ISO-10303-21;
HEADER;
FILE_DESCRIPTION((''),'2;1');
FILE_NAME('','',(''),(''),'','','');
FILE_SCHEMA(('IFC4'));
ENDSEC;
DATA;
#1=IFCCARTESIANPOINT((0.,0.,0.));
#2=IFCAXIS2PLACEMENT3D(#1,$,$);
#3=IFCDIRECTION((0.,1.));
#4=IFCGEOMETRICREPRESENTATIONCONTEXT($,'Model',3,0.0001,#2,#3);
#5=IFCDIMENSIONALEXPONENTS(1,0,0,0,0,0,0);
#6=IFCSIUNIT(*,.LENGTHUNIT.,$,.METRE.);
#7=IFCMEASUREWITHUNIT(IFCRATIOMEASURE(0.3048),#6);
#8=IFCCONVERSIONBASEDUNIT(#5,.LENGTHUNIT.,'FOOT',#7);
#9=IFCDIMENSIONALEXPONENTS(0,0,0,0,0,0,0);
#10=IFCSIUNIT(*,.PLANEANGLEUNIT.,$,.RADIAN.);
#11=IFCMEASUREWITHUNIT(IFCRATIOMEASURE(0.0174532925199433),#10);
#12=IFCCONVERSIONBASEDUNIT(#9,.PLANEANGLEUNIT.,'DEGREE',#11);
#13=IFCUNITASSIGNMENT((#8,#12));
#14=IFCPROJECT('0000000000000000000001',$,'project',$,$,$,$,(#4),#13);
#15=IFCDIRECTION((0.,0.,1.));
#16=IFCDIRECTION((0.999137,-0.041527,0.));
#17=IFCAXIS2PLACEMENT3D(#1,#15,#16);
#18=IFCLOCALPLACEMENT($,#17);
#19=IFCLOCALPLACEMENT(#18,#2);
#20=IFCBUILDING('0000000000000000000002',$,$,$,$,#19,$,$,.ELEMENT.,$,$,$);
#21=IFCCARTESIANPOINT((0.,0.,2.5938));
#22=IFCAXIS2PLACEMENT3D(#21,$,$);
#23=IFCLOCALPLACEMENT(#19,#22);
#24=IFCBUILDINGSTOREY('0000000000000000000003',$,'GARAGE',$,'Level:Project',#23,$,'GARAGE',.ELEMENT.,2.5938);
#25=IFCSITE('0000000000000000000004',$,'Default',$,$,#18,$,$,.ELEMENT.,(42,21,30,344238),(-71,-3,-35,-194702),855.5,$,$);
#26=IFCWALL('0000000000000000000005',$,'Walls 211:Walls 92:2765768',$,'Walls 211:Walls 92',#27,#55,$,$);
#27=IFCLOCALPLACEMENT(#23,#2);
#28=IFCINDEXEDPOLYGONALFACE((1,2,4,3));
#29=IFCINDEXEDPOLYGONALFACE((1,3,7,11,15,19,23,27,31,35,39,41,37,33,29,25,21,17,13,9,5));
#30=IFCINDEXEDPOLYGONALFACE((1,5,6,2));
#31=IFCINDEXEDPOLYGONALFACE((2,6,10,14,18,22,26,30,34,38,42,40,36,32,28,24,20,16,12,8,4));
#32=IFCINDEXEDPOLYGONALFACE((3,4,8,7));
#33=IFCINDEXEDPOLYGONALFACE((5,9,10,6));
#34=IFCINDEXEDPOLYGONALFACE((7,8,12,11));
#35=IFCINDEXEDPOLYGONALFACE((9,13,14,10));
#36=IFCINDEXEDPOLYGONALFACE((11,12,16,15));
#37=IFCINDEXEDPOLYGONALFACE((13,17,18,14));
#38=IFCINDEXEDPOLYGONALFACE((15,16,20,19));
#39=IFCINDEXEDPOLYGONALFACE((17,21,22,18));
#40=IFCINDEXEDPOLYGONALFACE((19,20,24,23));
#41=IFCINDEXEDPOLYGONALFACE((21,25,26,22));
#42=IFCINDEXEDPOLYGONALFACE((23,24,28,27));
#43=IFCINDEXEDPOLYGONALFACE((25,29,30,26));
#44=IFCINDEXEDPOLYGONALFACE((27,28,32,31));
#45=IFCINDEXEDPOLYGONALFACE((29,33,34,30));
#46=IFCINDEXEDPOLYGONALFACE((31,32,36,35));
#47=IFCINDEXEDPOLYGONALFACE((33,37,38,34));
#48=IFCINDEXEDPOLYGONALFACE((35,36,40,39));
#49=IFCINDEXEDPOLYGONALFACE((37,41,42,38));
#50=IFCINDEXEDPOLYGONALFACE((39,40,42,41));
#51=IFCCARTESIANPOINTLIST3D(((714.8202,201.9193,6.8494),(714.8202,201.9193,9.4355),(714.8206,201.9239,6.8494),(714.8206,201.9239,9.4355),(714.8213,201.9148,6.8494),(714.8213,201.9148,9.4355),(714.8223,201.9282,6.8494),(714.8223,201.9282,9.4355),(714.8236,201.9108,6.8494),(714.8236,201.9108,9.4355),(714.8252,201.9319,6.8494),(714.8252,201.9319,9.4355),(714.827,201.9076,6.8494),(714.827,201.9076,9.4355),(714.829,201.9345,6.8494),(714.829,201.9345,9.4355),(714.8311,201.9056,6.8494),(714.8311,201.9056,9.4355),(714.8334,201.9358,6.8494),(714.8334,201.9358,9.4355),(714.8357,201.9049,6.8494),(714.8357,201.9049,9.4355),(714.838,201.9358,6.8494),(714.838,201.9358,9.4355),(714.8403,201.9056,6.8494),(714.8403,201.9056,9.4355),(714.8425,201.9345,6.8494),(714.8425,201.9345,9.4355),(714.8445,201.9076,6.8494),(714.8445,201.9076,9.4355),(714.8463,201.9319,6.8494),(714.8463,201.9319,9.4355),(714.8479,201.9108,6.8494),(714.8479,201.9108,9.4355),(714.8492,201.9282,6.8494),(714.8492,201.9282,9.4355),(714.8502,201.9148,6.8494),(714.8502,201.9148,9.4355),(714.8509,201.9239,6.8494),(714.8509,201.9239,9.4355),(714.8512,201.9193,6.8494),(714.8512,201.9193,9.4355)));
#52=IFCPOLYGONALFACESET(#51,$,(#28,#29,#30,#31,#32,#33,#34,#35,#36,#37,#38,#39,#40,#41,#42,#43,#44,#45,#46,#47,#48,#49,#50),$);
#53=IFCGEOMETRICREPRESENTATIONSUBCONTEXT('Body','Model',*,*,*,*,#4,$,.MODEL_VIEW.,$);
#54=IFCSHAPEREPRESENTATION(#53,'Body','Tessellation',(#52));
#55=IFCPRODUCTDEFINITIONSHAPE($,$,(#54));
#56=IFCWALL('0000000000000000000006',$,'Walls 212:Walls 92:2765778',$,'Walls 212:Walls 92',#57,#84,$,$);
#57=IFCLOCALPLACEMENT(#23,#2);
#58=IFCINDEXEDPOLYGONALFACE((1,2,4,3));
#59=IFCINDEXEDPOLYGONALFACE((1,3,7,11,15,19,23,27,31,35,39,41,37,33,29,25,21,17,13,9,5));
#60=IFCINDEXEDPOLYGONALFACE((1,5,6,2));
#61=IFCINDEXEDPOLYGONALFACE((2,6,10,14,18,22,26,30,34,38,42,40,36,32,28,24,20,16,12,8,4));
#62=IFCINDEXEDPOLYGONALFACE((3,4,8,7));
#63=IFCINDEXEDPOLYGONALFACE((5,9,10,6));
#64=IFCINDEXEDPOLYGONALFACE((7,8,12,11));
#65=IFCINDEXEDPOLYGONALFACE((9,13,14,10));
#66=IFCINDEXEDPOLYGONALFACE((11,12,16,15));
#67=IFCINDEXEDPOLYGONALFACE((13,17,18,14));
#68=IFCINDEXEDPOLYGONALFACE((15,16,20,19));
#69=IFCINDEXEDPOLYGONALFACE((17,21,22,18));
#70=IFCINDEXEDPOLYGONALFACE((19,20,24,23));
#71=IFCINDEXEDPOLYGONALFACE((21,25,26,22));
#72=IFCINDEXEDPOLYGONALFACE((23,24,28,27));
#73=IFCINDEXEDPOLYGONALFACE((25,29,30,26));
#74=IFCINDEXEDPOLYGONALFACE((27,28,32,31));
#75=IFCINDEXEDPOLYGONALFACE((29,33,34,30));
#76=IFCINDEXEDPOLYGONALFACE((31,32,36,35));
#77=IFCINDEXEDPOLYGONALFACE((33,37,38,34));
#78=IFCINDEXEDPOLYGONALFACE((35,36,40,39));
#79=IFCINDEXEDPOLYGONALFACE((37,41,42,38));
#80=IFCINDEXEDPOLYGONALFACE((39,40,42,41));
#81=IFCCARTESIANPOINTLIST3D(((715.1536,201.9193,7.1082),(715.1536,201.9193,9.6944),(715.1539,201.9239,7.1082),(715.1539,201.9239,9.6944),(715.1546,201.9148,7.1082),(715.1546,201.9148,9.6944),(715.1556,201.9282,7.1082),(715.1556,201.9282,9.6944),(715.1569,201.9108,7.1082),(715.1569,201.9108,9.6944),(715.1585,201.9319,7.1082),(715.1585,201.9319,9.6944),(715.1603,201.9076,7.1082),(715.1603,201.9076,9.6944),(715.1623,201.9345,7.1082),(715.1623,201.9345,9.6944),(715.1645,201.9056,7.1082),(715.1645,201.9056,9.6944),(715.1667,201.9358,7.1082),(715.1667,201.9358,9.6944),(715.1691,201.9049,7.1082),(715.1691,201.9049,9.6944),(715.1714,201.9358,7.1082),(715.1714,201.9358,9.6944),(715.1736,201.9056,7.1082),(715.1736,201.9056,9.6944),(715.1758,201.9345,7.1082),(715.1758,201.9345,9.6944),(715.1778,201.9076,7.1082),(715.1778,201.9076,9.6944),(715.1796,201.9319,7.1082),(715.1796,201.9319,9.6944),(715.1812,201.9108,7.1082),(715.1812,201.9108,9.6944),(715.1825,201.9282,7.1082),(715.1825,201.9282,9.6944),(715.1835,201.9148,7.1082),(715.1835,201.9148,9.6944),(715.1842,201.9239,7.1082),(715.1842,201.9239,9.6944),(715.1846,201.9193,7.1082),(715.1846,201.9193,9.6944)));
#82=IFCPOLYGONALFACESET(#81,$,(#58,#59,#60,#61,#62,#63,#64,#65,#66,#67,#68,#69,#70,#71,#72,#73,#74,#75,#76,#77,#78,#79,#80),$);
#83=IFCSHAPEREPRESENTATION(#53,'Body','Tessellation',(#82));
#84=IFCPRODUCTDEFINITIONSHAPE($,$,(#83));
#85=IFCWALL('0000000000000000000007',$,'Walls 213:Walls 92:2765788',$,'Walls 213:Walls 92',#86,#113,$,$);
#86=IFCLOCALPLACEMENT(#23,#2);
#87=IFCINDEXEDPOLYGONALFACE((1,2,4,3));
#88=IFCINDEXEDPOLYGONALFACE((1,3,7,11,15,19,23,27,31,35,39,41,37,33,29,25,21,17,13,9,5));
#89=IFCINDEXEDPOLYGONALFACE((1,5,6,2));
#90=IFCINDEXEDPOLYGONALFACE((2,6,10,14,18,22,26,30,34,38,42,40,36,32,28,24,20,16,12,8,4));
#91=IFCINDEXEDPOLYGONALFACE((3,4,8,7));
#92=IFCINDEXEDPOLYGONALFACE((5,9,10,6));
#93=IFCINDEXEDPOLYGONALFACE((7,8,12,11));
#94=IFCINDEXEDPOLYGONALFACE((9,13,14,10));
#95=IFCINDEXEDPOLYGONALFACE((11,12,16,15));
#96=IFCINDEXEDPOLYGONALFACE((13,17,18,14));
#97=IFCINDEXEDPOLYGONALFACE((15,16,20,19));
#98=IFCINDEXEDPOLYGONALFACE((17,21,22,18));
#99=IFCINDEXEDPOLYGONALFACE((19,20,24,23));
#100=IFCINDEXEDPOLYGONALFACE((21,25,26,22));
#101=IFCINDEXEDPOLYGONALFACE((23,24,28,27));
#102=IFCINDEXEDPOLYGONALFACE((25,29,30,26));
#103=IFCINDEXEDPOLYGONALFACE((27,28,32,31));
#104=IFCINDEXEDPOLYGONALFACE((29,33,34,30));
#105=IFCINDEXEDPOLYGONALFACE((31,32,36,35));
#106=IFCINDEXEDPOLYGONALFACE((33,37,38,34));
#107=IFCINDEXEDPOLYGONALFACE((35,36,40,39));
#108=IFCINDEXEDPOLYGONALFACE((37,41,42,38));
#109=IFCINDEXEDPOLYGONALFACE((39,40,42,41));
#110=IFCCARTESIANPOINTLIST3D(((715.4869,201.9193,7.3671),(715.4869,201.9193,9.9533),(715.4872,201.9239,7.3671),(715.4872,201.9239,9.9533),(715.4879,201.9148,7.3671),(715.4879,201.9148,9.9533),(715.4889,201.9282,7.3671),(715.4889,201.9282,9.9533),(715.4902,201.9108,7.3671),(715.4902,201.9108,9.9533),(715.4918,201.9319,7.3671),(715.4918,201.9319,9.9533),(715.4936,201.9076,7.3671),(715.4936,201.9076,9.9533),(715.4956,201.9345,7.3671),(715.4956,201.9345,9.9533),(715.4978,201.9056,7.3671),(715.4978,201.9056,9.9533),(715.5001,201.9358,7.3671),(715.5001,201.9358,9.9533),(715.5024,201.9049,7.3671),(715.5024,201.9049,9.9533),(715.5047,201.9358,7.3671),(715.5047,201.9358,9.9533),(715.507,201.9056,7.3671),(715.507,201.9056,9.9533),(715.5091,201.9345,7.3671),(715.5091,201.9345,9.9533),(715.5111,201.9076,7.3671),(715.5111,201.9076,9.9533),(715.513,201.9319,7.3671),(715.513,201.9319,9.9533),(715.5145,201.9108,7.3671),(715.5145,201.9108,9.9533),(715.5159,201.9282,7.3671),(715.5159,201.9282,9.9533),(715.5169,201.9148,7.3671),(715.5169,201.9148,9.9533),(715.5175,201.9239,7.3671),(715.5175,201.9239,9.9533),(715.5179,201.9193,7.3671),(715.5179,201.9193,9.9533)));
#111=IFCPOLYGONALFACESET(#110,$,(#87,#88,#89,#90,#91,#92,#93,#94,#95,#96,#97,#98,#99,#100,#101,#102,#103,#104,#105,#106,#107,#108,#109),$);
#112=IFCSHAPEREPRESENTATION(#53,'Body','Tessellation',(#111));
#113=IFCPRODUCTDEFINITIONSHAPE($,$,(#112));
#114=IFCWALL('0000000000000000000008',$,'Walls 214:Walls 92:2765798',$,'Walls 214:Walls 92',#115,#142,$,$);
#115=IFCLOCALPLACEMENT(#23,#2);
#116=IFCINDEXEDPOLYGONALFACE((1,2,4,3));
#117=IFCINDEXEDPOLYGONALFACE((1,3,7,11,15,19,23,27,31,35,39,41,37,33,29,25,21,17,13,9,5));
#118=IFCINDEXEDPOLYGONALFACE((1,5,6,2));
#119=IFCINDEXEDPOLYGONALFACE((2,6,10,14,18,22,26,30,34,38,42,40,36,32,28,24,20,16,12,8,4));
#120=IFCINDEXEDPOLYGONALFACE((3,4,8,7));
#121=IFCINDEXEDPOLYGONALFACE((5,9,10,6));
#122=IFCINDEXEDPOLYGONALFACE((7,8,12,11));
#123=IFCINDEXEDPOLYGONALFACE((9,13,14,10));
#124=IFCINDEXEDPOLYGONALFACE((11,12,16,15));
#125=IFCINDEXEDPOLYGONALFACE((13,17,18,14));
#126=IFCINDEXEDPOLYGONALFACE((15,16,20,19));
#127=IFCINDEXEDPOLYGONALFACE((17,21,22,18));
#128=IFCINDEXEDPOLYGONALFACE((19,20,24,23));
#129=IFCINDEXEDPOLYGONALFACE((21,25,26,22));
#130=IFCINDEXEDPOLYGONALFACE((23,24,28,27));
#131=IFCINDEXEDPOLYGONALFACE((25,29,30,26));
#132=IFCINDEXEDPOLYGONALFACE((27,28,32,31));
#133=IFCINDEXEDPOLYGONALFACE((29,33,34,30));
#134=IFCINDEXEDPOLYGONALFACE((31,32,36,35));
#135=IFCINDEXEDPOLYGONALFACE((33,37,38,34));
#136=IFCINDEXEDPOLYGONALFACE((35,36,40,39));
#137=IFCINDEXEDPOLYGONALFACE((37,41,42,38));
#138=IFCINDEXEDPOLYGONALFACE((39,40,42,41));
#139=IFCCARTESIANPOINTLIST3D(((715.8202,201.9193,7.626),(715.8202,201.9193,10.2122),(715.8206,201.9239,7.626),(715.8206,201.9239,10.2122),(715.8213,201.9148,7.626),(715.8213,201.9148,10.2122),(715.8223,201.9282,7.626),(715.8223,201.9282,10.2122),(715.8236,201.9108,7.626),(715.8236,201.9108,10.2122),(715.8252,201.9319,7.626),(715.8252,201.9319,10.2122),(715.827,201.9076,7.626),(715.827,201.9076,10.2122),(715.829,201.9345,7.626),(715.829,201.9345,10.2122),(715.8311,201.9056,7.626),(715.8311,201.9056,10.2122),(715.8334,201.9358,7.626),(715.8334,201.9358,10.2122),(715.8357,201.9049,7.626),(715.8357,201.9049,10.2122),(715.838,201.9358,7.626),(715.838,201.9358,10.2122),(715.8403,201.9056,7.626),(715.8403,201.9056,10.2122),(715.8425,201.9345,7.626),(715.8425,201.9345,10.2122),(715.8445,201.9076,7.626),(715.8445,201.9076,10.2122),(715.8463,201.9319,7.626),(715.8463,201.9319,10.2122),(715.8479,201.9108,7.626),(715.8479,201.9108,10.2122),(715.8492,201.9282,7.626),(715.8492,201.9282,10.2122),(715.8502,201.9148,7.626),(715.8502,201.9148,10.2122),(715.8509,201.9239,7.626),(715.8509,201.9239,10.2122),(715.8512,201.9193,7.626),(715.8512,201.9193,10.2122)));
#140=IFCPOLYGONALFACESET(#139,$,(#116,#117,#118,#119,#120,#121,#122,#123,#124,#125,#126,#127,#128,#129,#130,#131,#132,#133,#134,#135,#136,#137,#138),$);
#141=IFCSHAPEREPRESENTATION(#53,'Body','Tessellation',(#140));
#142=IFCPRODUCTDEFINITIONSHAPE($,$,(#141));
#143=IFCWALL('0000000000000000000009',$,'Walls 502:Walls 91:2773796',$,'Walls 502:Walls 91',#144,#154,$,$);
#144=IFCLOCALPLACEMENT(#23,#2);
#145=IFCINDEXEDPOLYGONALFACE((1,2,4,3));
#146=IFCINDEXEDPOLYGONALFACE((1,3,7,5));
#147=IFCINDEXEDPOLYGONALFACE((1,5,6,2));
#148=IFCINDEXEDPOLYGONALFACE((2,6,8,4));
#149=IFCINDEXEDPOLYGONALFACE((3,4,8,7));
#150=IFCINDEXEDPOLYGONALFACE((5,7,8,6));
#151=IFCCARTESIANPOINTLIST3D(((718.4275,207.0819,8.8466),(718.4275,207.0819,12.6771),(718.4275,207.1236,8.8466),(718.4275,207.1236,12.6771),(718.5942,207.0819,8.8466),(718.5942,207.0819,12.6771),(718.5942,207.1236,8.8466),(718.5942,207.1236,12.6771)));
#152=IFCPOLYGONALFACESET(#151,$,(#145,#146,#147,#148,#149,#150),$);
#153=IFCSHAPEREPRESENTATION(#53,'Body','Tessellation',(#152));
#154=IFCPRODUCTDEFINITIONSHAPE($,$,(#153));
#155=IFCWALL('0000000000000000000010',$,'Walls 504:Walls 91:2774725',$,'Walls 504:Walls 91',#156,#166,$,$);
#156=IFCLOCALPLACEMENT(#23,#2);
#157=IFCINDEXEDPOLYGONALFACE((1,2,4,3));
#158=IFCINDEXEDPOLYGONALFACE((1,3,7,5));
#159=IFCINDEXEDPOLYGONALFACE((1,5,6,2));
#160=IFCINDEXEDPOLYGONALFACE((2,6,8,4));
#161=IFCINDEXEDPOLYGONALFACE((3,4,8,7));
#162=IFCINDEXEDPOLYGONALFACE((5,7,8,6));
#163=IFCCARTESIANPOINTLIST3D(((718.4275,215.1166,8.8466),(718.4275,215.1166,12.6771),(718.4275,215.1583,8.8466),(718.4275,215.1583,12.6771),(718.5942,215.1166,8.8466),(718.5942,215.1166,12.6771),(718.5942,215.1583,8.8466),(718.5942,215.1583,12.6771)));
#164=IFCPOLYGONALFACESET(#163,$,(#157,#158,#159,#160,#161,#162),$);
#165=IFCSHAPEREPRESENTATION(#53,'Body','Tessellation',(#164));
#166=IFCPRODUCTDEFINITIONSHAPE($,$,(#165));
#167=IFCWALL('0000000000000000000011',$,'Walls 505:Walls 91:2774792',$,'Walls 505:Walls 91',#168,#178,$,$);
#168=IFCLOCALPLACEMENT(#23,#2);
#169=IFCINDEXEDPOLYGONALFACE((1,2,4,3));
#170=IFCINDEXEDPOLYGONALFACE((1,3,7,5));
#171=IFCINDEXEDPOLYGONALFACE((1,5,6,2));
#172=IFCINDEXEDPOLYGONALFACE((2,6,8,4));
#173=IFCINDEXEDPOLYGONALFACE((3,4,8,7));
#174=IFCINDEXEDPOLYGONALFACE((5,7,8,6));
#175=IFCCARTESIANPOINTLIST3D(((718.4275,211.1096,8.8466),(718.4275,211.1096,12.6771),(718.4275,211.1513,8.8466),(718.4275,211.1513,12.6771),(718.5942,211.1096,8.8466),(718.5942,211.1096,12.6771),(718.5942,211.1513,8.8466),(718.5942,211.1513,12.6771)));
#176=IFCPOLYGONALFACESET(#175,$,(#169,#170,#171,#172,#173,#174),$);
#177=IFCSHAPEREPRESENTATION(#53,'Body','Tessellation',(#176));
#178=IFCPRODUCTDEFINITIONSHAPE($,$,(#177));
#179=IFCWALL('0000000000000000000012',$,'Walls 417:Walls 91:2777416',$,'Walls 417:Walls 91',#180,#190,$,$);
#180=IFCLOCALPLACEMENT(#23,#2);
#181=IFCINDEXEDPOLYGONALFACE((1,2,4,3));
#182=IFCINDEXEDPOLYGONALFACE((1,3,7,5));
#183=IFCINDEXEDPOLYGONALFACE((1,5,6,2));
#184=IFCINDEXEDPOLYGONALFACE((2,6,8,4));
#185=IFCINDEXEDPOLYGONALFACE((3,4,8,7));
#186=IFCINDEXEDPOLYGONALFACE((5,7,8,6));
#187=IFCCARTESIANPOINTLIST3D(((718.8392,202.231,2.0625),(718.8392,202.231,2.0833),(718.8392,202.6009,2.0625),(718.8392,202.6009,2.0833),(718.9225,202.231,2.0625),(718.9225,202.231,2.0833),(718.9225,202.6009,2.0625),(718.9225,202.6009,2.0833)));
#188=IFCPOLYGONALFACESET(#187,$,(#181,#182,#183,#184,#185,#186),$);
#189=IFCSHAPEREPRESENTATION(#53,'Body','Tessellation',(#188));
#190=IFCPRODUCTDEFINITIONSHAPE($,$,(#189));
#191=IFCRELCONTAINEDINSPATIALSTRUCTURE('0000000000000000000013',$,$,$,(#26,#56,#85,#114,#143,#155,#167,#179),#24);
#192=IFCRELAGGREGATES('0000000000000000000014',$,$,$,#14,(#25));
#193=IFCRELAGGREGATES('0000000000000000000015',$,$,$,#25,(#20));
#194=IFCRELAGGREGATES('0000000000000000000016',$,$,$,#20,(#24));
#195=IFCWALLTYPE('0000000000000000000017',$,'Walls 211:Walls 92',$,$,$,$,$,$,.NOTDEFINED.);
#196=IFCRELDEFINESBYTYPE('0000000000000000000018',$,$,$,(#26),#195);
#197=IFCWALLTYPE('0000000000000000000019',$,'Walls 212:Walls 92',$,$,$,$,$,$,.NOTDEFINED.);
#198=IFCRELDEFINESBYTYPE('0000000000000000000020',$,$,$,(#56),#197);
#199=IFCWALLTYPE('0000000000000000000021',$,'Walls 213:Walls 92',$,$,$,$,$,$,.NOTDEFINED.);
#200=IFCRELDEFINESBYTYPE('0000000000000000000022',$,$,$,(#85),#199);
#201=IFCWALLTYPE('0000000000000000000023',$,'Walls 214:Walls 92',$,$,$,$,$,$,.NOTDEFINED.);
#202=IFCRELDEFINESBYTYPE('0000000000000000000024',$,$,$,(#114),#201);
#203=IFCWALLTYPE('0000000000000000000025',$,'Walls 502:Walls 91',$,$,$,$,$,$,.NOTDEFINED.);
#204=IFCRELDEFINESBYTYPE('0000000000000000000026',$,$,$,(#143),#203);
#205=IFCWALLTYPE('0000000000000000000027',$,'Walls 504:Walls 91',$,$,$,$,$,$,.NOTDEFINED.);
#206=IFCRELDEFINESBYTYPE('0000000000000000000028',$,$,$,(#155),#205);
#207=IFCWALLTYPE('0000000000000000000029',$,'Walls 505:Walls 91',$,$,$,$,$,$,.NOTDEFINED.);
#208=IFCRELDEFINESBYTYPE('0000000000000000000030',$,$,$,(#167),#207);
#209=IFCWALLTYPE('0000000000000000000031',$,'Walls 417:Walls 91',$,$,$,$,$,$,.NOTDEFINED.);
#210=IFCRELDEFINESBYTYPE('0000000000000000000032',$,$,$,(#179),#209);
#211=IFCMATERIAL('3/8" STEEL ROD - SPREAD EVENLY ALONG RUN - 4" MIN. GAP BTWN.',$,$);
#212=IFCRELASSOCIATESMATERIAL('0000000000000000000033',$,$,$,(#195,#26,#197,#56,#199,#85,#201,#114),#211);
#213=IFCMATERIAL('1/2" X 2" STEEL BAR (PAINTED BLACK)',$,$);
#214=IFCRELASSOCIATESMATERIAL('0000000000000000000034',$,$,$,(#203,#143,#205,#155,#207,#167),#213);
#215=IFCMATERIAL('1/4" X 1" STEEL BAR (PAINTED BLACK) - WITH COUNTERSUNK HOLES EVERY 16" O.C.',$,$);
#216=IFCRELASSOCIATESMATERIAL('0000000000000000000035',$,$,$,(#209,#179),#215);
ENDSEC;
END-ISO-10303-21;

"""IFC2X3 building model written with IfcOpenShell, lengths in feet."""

from ifc_helpers import new_model, entity, si_unit, converted_unit, direction, frame, frame_2d, origin, origin_2d_with_axis, place, context, subcontext, project, spatial, rectangle, circle, extrude, material, type_object, element, save


model = new_model("IFC2X3")

# Units and contexts
model_context = context("Model", 3, precision=0.0001, world=origin(), true_north=direction((0.0, 1.0)))
body_context = subcontext(model_context, "Body", "Model", "MODEL_VIEW")
ifc_project = project(units=[converted_unit("LENGTHUNIT", "FOOT", entity("IfcRatioMeasure", 0.3048), si_unit("LENGTHUNIT", "METRE"), dimensions=[1, 0, 0, 0, 0, 0, 0]), converted_unit("PLANEANGLEUNIT", "DEGREE", entity("IfcRatioMeasure", 0.0174532925199433), si_unit("PLANEANGLEUNIT", "RADIAN"), dimensions=[0, 0, 0, 0, 0, 0, 0])], contexts=[model_context])

# Site, building, storey
site_placement = place(None, frame((0.0, 0.0, 0.0), z_axis=(0.0, 0.0, 1.0), x_axis=(0.999137, -0.041527, 0.0)))
site = spatial("IfcSite", under=ifc_project, at=site_placement, Name="Default", CompositionType="ELEMENT", RefLatitude=(42, 21, 30, 344238), RefLongitude=(-71, -3, -35, -194702), RefElevation=855.5)
building_placement = place(site_placement, origin())
building = spatial("IfcBuilding", under=site, at=building_placement, CompositionType="ELEMENT")
storey_placement = place(building_placement, frame((0.0, 0.0, 2.5938)))
storey = spatial("IfcBuildingStorey", under=building, at=storey_placement, Name="GARAGE", ObjectType="Level:Project", LongName="GARAGE", CompositionType="ELEMENT", Elevation=2.5938)

# Walls
ifc_material_1 = material(Name="3/8\" STEEL ROD - SPREAD EVENLY ALONG RUN - 4\" MIN. GAP BTWN.")
wall_type_1 = type_object("IfcWallType", Name="Walls 211:Walls 92", PredefinedType="NOTDEFINED", material=ifc_material_1)
wall_1_placement = place(storey_placement, frame((714.8202, 201.9049, 6.8494)))
element("IfcWall", 1, at=wall_1_placement, inside=storey, type_object=wall_type_1, material=ifc_material_1, Name="Walls 211:Walls 92:2765768", ObjectType="Walls 211:Walls 92", context=body_context, shape_type="SweptSolid", body=[
    extrude(circle(Radius=0.0155, at=origin_2d_with_axis()), frame((0.0155, 0.0155, 0.0), z_axis=(0.0, 0.0, 1.0), x_axis=(0.0, -1.0, 0.0)), (0.0, 0.0, 1.0), 2.5862),
])
wall_type_2 = type_object("IfcWallType", Name="Walls 212:Walls 92", PredefinedType="NOTDEFINED", material=ifc_material_1)
wall_2_placement = place(storey_placement, frame((715.1535, 201.9049, 7.1082)))
element("IfcWall", 2, at=wall_2_placement, inside=storey, type_object=wall_type_2, material=ifc_material_1, Name="Walls 212:Walls 92:2765778", ObjectType="Walls 212:Walls 92", context=body_context, shape_type="SweptSolid", body=[
    extrude(circle(Radius=0.0155, at=origin_2d_with_axis()), frame((0.0155, 0.0155, 0.0), z_axis=(0.0, 0.0, 1.0), x_axis=(0.0, -1.0, 0.0)), (0.0, 0.0, 1.0), 2.5862),
])
wall_type_3 = type_object("IfcWallType", Name="Walls 213:Walls 92", PredefinedType="NOTDEFINED", material=ifc_material_1)
wall_3_placement = place(storey_placement, frame((715.4869, 201.9049, 7.3671)))
element("IfcWall", 3, at=wall_3_placement, inside=storey, type_object=wall_type_3, material=ifc_material_1, Name="Walls 213:Walls 92:2765788", ObjectType="Walls 213:Walls 92", context=body_context, shape_type="SweptSolid", body=[
    extrude(circle(Radius=0.0155, at=origin_2d_with_axis()), frame((0.0155, 0.0155, 0.0), z_axis=(0.0, 0.0, 1.0), x_axis=(0.0, -1.0, 0.0)), (0.0, 0.0, 1.0), 2.5862),
])
wall_type_4 = type_object("IfcWallType", Name="Walls 214:Walls 92", PredefinedType="NOTDEFINED", material=ifc_material_1)
wall_4_placement = place(storey_placement, frame((715.8202, 201.9049, 7.626)))
element("IfcWall", 4, at=wall_4_placement, inside=storey, type_object=wall_type_4, material=ifc_material_1, Name="Walls 214:Walls 92:2765798", ObjectType="Walls 214:Walls 92", context=body_context, shape_type="SweptSolid", body=[
    extrude(circle(Radius=0.0155, at=origin_2d_with_axis()), frame((0.0155, 0.0155, 0.0), z_axis=(0.0, 0.0, 1.0), x_axis=(0.0, -1.0, 0.0)), (0.0, 0.0, 1.0), 2.5862),
])
ifc_material_2 = material(Name="1/2\" X 2\" STEEL BAR (PAINTED BLACK)")
wall_type_5 = type_object("IfcWallType", Name="Walls 502:Walls 91", PredefinedType="NOTDEFINED", material=ifc_material_2)
wall_5_placement = place(storey_placement, frame((718.4275, 207.0819, 8.8466)))
element("IfcWall", 5, at=wall_5_placement, inside=storey, type_object=wall_type_5, material=ifc_material_2, Name="Walls 502:Walls 91:2773796", ObjectType="Walls 502:Walls 91", context=body_context, shape_type="SweptSolid", body=[
    extrude(rectangle(XDim=0.1667, YDim=0.0417, at=frame_2d((0.0, 0.0), x_axis=(1.0, 0.0))), frame((0.0834, 0.0209, 0.0)), (0.0, 0.0, 1.0), 3.8305),
])
wall_type_6 = type_object("IfcWallType", Name="Walls 504:Walls 91", PredefinedType="NOTDEFINED", material=ifc_material_2)
wall_6_placement = place(storey_placement, frame((718.4275, 215.1166, 8.8466)))
element("IfcWall", 6, at=wall_6_placement, inside=storey, type_object=wall_type_6, material=ifc_material_2, Name="Walls 504:Walls 91:2774725", ObjectType="Walls 504:Walls 91", context=body_context, shape_type="SweptSolid", body=[
    extrude(rectangle(XDim=0.1667, YDim=0.0417, at=origin_2d_with_axis()), frame((0.0834, 0.0209, 0.0)), (0.0, 0.0, 1.0), 3.8305),
])
wall_type_7 = type_object("IfcWallType", Name="Walls 505:Walls 91", PredefinedType="NOTDEFINED", material=ifc_material_2)
wall_7_placement = place(storey_placement, frame((718.4275, 211.1096, 8.8466)))
element("IfcWall", 7, at=wall_7_placement, inside=storey, type_object=wall_type_7, material=ifc_material_2, Name="Walls 505:Walls 91:2774792", ObjectType="Walls 505:Walls 91", context=body_context, shape_type="SweptSolid", body=[
    extrude(rectangle(XDim=0.1667, YDim=0.0417, at=frame_2d((0.0, 0.0), x_axis=(1.0, 0.0))), frame((0.0834, 0.0209, 0.0)), (0.0, 0.0, 1.0), 3.8305),
])
ifc_material_3 = material(Name="1/4\" X 1\" STEEL BAR (PAINTED BLACK) - WITH COUNTERSUNK HOLES EVERY 16\" O.C.")
wall_type_8 = type_object("IfcWallType", Name="Walls 417:Walls 91", PredefinedType="NOTDEFINED", material=ifc_material_3)
wall_8_placement = place(storey_placement, frame((718.8392, 202.231, 2.0625), z_axis=(0.0, 0.0, 1.0), x_axis=(0.0, 1.0, 0.0)))
element("IfcWall", 8, at=wall_8_placement, inside=storey, type_object=wall_type_8, material=ifc_material_3, Name="Walls 417:Walls 91:2777416", ObjectType="Walls 417:Walls 91", context=body_context, shape_type="SweptSolid", body=[
    extrude(rectangle(XDim=0.37, YDim=0.0833, at=frame_2d((0.0, 0.0), x_axis=(1.0, 0.0))), frame((0.185, -0.0417, 0.0), z_axis=(0.0, 0.0, 1.0), x_axis=(-1.0, 0.0, 0.0)), (0.0, 0.0, 1.0), 0.0208),
])

save(model, "model.ifc")
